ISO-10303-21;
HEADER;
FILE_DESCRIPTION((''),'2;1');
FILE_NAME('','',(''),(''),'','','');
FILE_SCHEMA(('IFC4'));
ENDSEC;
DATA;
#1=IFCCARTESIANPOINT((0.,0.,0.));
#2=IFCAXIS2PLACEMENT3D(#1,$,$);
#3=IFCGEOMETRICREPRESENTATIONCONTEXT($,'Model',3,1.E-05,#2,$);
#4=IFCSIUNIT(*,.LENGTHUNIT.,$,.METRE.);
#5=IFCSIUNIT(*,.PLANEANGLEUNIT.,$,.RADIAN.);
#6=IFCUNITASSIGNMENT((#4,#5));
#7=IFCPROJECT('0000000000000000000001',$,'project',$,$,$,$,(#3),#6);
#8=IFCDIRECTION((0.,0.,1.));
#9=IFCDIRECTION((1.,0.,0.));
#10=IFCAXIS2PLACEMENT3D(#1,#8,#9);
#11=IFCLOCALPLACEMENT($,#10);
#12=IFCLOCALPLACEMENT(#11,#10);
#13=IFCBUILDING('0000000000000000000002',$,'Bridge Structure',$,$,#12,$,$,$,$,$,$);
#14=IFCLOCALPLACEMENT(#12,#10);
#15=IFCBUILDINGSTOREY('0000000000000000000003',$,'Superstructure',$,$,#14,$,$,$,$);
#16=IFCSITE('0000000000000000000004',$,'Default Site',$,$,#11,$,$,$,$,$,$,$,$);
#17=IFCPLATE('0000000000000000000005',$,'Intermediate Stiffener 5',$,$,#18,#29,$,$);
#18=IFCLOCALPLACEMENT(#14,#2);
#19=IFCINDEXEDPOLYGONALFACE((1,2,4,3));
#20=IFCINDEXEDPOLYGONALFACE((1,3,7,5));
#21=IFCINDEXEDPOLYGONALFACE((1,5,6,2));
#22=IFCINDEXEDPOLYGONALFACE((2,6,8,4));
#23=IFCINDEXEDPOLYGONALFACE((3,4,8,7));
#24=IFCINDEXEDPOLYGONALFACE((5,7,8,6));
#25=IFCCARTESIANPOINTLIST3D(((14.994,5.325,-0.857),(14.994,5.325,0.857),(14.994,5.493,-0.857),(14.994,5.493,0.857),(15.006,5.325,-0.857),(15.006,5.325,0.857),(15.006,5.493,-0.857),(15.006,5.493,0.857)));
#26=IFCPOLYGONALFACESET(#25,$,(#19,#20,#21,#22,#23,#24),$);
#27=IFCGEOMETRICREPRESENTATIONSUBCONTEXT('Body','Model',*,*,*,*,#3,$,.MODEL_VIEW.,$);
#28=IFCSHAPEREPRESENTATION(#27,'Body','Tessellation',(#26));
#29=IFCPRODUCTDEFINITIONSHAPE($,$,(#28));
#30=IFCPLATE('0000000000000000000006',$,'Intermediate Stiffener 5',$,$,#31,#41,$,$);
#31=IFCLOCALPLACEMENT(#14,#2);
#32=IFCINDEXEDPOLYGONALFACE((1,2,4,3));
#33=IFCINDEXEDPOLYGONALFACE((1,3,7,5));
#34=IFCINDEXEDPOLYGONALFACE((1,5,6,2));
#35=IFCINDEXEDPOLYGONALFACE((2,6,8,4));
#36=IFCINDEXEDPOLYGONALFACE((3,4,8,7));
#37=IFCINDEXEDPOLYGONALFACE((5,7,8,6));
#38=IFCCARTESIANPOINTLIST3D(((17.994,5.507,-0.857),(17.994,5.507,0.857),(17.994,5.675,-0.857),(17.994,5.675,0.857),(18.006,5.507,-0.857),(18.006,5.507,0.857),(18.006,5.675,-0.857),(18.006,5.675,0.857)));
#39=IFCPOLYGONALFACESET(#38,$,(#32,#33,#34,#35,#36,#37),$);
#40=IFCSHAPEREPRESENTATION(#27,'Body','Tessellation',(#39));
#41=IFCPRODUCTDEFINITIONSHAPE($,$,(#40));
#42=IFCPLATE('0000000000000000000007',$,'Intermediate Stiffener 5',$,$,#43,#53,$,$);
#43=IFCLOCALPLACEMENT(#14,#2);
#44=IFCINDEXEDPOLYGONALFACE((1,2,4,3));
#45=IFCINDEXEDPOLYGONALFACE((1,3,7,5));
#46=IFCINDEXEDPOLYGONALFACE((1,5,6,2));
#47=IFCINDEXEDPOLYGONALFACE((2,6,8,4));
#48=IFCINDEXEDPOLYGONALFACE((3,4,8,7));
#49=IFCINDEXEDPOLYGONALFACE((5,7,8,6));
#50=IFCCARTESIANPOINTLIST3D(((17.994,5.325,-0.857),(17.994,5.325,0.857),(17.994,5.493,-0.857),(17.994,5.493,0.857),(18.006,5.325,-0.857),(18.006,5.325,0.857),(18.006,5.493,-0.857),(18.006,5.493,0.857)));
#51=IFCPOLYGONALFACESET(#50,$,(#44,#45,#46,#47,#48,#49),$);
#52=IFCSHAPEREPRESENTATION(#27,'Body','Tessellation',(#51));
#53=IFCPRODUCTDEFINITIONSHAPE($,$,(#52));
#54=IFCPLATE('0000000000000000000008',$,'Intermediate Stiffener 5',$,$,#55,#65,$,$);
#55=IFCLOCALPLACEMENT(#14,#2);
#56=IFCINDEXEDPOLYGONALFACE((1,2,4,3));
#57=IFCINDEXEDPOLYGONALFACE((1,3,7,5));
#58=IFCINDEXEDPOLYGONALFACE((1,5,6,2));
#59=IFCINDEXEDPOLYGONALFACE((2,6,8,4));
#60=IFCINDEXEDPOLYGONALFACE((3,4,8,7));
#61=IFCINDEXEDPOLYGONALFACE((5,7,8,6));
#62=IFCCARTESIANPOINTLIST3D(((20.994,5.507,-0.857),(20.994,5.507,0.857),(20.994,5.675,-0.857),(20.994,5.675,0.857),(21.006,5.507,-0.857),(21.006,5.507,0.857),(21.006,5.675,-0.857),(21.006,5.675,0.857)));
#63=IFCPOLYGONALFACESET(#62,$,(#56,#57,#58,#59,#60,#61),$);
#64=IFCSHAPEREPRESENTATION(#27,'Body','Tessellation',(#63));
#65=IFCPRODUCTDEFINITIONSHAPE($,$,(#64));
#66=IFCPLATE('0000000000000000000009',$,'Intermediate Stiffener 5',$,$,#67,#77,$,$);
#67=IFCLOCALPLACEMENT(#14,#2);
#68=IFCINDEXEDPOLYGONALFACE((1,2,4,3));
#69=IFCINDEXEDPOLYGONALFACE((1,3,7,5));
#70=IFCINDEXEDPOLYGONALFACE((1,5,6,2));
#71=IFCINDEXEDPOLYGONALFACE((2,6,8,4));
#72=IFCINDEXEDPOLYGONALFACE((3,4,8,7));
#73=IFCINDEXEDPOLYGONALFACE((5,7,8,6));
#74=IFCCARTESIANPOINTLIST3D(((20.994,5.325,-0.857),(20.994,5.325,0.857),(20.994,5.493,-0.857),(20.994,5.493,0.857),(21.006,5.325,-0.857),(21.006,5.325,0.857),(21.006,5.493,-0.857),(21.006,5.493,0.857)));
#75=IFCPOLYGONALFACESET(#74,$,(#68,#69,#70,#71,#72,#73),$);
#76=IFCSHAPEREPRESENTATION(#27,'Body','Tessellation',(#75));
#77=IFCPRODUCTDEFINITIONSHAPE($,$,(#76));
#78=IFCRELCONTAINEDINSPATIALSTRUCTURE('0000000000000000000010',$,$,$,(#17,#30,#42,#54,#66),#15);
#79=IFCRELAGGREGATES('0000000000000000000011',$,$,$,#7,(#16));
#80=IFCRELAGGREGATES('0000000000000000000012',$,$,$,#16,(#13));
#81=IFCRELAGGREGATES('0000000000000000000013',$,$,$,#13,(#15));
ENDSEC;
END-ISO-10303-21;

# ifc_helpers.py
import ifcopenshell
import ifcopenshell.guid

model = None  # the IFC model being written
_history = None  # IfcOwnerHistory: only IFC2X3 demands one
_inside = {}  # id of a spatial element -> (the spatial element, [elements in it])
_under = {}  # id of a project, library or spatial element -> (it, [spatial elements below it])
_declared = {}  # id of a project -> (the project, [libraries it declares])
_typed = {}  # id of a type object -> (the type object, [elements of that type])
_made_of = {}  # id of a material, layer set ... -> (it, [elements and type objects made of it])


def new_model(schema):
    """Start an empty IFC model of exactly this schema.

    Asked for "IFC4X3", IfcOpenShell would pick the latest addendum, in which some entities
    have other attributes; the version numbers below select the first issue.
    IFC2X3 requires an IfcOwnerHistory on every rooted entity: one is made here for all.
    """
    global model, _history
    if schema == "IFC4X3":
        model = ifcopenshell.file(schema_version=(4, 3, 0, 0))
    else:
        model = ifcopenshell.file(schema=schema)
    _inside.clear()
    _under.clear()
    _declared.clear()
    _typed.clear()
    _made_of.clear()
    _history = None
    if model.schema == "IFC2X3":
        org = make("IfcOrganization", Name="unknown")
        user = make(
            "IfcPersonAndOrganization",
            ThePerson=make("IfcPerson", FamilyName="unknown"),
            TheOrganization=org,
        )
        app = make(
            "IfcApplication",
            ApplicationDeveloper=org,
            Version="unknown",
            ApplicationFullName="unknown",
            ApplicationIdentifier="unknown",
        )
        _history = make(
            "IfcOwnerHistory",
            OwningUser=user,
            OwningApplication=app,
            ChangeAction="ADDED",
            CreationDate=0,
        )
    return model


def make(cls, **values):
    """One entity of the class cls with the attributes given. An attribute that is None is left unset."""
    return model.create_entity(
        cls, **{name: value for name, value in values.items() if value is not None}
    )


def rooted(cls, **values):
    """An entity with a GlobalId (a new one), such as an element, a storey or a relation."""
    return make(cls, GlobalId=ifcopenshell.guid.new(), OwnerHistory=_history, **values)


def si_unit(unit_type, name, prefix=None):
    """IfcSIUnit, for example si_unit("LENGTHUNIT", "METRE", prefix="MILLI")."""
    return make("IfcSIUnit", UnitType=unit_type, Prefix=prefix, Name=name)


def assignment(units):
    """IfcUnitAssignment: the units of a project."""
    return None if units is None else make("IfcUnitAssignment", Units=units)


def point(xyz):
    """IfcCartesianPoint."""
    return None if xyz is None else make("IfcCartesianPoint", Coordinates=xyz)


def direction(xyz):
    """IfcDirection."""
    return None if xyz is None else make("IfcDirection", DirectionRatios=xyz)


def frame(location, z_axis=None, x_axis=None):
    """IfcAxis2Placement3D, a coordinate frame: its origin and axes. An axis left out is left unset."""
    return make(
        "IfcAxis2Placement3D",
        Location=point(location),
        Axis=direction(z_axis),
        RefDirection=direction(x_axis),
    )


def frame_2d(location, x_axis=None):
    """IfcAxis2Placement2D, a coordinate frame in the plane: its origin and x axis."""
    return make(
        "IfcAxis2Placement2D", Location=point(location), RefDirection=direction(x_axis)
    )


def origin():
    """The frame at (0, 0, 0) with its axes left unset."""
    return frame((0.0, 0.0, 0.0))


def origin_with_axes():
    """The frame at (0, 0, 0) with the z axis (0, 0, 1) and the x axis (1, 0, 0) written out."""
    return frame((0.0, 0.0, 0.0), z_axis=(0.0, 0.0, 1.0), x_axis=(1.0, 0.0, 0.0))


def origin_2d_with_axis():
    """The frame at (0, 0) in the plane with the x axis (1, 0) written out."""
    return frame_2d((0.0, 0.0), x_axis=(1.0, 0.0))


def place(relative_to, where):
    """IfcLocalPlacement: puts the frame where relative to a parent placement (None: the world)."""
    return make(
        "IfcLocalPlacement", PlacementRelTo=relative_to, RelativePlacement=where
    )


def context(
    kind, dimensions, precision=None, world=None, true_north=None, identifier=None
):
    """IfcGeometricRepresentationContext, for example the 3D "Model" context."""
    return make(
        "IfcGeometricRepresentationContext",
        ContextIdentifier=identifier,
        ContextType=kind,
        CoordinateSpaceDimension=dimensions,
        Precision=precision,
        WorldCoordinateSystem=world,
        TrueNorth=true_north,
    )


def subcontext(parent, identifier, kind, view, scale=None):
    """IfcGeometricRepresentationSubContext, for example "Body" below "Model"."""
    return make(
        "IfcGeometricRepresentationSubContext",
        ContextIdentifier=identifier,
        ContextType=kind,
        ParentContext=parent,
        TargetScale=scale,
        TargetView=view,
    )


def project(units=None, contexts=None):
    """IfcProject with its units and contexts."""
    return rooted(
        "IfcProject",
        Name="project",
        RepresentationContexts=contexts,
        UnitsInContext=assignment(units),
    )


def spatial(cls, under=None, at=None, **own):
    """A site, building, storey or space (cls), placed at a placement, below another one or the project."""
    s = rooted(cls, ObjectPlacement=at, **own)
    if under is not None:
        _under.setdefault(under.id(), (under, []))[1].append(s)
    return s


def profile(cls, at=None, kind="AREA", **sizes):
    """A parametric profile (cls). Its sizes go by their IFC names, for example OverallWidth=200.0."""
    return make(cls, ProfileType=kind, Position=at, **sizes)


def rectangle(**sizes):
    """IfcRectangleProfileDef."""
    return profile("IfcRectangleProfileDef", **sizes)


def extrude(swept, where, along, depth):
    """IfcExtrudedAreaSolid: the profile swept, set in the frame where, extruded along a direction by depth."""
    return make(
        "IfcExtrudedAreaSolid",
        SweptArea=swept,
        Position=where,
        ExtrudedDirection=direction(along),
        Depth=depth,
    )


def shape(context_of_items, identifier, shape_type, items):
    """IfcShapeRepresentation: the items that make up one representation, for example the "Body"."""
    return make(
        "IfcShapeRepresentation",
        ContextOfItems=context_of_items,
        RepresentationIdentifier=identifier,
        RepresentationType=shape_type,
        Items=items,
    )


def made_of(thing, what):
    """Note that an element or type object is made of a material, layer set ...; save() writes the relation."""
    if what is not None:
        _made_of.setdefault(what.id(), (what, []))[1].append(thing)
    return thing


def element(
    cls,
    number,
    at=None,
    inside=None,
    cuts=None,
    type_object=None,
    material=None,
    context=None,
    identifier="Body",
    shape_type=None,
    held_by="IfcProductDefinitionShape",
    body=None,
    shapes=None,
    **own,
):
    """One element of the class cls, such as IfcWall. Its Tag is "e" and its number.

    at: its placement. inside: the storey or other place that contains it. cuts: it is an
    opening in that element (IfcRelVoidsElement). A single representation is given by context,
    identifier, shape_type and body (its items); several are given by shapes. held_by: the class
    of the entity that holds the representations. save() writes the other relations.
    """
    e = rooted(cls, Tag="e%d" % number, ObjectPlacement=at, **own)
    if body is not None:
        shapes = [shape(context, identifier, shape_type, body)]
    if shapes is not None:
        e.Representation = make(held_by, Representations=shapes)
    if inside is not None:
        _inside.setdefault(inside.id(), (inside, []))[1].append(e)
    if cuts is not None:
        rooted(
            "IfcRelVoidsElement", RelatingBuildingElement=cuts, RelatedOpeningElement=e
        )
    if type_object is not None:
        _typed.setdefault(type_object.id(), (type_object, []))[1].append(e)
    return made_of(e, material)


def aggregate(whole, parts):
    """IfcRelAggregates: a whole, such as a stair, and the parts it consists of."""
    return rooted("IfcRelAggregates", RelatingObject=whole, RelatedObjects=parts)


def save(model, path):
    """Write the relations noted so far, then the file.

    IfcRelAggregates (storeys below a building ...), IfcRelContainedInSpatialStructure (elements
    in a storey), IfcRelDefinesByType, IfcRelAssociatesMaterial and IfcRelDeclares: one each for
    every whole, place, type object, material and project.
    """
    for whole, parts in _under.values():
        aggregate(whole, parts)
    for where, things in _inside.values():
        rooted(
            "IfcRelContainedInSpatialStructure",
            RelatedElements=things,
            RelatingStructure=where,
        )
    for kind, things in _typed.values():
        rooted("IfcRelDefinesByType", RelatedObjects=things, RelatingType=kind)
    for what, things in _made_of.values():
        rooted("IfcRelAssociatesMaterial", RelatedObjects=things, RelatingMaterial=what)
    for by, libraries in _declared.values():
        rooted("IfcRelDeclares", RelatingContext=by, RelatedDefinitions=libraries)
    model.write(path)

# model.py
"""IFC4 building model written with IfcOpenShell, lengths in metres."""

from ifc_helpers import new_model, si_unit, frame, origin, origin_with_axes, origin_2d_with_axis, place, context, subcontext, project, spatial, rectangle, extrude, element, save


model = new_model("IFC4")

# Units and contexts
model_context = context("Model", 3, precision=1e-05, world=origin())
body_context = subcontext(model_context, "Body", "Model", "MODEL_VIEW")
ifc_project = project(units=[si_unit("LENGTHUNIT", "METRE"), si_unit("PLANEANGLEUNIT", "RADIAN")], contexts=[model_context])

# Site, building, storey
site_placement = place(None, origin_with_axes())
site = spatial("IfcSite", under=ifc_project, at=site_placement, Name="Default Site")
building_placement = place(site_placement, origin_with_axes())
building = spatial("IfcBuilding", under=site, at=building_placement, Name="Bridge Structure")
storey_placement = place(building_placement, origin_with_axes())
storey = spatial("IfcBuildingStorey", under=building, at=storey_placement, Name="Superstructure")

# Plates
for number, where, z_axis, x_axis, name in (
    (1, (15.0, 5.409, -0.857), (0.0, 0.0, 1.0), (1.0, 0.0, 0.0), "Intermediate Stiffener 5"),
    (2, (18.0, 5.591, -0.857), (0.0, 0.0, 1.0), (1.0, 0.0, 0.0), "Intermediate Stiffener 5"),
    (3, (18.0, 5.409, -0.857), (0.0, 0.0, 1.0), (1.0, 0.0, 0.0), "Intermediate Stiffener 5"),
    (4, (21.0, 5.591, -0.857), (0.0, 0.0, 1.0), (1.0, 0.0, 0.0), "Intermediate Stiffener 5"),
    (5, (21.0, 5.409, -0.857), (0.0, 0.0, 1.0), (1.0, 0.0, 0.0), "Intermediate Stiffener 5"),
):
    element("IfcPlate", number, at=place(storey_placement, frame(where, z_axis=z_axis, x_axis=x_axis)), inside=storey, Name=name, context=body_context, shape_type="SweptSolid", body=[
        extrude(rectangle(XDim=0.012, YDim=0.168, at=origin_2d_with_axis()), origin_with_axes(), (0.0, 0.0, 1.0), 1.714),
    ])

save(model, "model.ifc")
